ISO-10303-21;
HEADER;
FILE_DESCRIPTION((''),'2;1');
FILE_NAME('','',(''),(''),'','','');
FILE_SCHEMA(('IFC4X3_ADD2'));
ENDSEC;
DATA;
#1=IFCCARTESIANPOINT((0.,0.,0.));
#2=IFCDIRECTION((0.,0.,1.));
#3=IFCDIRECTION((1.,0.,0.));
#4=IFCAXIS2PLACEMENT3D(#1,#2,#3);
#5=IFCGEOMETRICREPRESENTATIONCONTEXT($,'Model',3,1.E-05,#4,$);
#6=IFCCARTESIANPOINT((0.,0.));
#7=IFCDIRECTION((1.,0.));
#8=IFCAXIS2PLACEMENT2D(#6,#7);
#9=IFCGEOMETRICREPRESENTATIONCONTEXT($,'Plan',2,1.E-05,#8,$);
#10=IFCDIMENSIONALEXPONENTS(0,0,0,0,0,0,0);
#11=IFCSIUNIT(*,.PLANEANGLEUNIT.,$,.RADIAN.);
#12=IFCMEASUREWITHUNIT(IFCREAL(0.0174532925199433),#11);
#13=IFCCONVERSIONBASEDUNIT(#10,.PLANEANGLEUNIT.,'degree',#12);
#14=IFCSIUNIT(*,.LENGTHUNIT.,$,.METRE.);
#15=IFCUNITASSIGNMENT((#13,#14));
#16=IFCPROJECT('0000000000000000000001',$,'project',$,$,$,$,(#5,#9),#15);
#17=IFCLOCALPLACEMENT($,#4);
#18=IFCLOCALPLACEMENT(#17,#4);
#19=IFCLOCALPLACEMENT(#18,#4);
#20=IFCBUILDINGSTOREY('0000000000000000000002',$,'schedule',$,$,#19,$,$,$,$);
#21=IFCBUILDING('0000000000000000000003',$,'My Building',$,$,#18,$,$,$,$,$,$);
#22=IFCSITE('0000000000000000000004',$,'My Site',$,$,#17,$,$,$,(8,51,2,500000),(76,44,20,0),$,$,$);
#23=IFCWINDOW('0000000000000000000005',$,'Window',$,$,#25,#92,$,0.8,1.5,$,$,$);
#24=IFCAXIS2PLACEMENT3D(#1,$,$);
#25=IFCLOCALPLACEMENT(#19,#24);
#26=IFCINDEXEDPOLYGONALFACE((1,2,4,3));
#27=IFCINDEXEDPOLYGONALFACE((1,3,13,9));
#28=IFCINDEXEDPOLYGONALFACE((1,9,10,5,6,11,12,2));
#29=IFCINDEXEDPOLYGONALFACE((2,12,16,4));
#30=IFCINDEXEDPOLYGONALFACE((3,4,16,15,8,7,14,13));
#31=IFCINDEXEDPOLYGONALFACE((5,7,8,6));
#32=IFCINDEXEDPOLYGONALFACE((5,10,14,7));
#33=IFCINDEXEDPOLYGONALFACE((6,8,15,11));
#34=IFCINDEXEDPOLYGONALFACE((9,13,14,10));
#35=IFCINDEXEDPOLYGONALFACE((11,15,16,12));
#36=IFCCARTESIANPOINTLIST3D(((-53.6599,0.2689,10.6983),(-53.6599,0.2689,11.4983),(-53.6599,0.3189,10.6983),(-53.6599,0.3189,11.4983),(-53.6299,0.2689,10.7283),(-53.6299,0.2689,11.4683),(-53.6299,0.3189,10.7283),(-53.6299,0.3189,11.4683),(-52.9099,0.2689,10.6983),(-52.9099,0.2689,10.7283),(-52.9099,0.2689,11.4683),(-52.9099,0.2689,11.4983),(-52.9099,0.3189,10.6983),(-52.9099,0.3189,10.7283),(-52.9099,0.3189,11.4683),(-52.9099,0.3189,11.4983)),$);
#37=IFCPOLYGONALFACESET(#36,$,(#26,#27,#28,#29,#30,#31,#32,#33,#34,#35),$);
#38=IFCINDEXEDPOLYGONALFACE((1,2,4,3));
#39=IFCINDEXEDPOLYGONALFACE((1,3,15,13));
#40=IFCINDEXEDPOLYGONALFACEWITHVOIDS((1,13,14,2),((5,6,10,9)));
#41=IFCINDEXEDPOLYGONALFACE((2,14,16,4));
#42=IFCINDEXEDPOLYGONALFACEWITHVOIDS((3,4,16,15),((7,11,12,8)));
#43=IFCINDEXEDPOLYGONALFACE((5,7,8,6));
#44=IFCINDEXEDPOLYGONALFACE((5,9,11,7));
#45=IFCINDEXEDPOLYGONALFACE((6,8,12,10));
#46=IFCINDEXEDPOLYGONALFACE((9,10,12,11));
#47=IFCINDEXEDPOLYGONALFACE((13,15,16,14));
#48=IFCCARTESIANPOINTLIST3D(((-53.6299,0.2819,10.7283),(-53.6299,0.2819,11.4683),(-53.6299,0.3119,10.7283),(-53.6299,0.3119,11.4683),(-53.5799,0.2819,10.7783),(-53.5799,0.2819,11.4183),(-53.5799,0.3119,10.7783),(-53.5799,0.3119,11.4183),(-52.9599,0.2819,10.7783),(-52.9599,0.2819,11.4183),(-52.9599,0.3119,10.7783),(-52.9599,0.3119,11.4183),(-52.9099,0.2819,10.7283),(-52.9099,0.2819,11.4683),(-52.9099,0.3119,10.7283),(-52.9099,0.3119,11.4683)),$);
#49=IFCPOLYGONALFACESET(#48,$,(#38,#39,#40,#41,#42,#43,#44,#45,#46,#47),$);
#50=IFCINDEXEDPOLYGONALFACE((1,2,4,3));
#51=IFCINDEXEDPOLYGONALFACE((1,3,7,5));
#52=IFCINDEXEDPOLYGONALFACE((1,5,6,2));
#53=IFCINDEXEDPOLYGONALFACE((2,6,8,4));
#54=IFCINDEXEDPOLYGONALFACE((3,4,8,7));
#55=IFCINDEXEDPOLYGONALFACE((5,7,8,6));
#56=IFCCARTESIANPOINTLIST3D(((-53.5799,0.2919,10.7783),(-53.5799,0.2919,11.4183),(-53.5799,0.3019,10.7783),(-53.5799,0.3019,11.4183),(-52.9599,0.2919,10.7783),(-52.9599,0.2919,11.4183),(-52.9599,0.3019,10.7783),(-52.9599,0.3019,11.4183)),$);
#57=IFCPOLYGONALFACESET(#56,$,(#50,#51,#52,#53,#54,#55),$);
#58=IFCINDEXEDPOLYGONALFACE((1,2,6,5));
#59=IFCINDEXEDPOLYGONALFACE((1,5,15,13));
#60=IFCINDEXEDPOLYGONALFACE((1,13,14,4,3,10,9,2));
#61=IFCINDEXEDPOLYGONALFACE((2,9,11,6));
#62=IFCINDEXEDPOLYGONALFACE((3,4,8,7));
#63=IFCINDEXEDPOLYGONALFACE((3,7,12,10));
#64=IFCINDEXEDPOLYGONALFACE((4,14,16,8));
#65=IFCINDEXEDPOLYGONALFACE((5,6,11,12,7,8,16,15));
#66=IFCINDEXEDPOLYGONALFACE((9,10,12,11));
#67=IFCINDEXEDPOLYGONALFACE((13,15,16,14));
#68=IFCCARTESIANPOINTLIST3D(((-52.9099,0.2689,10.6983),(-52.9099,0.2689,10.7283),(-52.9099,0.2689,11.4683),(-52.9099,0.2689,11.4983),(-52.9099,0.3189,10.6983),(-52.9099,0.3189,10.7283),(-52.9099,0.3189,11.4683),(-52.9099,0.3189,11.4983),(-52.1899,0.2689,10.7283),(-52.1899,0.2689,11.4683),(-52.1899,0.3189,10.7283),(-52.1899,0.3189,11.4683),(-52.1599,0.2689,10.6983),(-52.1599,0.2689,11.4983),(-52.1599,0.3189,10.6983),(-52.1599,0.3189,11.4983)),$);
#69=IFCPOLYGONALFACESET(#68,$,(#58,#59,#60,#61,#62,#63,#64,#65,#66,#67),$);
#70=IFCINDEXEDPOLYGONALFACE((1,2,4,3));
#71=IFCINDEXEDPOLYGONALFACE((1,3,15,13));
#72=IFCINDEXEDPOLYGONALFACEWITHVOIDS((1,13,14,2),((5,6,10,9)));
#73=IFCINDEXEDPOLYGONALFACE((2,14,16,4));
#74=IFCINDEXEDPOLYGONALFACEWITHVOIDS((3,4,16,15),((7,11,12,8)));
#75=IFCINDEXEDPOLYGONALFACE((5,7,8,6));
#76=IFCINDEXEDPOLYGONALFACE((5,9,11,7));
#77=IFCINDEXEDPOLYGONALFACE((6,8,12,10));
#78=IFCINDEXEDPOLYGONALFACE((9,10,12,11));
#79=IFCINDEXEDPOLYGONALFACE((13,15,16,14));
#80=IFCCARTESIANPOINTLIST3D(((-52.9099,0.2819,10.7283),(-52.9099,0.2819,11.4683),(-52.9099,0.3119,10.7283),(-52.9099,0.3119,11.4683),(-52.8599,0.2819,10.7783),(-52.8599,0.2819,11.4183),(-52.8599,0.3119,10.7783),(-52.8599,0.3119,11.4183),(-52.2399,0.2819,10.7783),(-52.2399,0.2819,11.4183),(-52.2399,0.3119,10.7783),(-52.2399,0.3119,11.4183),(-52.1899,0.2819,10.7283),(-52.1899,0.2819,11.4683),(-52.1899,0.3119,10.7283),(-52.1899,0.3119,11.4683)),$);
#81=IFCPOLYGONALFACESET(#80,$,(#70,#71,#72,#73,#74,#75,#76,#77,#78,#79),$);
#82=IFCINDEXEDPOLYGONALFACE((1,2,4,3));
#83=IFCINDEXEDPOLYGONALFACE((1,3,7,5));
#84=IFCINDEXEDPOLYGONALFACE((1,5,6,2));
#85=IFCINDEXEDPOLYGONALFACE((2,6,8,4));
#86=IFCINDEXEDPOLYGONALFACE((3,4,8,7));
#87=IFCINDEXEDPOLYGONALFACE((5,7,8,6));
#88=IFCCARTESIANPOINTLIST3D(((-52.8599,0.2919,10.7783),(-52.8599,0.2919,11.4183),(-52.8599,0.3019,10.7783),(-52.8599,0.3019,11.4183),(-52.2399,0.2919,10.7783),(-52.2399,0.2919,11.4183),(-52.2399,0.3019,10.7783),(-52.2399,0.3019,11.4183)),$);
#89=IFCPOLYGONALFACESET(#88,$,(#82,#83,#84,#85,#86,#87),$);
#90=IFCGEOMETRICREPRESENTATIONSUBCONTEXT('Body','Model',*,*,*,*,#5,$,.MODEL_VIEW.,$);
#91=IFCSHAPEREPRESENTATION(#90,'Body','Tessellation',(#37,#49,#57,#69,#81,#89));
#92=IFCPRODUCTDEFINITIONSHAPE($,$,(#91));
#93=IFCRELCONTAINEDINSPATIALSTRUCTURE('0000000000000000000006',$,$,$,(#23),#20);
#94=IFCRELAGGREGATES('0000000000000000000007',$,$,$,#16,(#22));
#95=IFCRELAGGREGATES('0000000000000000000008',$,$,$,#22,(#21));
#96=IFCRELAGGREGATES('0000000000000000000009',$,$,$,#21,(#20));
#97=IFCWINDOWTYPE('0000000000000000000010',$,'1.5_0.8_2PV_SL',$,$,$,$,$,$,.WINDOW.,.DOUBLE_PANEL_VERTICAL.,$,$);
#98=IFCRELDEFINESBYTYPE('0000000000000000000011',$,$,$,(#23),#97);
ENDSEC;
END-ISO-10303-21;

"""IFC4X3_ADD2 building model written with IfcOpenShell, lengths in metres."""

from ifc_helpers import new_model, entity, si_unit, converted_unit, frame, origin_with_axes, origin_2d_with_axis, place, context, subcontext, project, spatial, line, indexed_curve, outline, extrude, shape, source, transform, mapped, type_object, type_shapes, element, save


model = new_model("IFC4X3_ADD2")

# Units and contexts
model_context = context("Model", 3, precision=1e-05, world=origin_with_axes())
plan_context = context("Plan", 2, precision=1e-05, world=origin_2d_with_axis())
body_context_1 = subcontext(model_context, "Body", "Model", "MODEL_VIEW")
body_context_2 = subcontext(plan_context, "Body", "Plan", "PLAN_VIEW")
ifc_project = project(units=[converted_unit("PLANEANGLEUNIT", "degree", entity("IfcReal", 0.0174532925199433), si_unit("PLANEANGLEUNIT", "RADIAN"), dimensions=[0, 0, 0, 0, 0, 0, 0]), si_unit("LENGTHUNIT", "METRE")], contexts=[model_context, plan_context])

# Site, building, storey
site_placement = place(None, origin_with_axes())
site = spatial("IfcSite", under=ifc_project, at=site_placement, Name="My Site", RefLatitude=(8, 51, 2, 500000), RefLongitude=(76, 44, 20, 0))
building_placement = place(site_placement, origin_with_axes())
building = spatial("IfcBuilding", under=site, at=building_placement, Name="My Building")
storey_placement = place(building_placement, origin_with_axes())
storey = spatial("IfcBuildingStorey", under=building, at=storey_placement, Name="schedule")

# Window
placement_1 = place(storey_placement, frame((-67.8485, 0.2689, 3.1152), z_axis=(0.0, 0.0, 1.0), x_axis=(1.0, 0.0, 0.0)))
window_type_1 = type_object("IfcWindowType", Name="1.5_0.8_2PV_SL", PartitioningType="DOUBLE_PANEL_VERTICAL", PredefinedType="WINDOW")
shared_shape_1 = source(origin_with_axes(), body_context_1, "Body", "SweptSolid", [
    extrude(outline(indexed_curve([(0.75, 0.0), (0.0, 0.0), (0.0, 0.8), (0.75, 0.8), (0.75, 0.77), (0.03, 0.77), (0.03, 0.03), (0.75, 0.03)], segments=[line(1, 2, 3, 4, 5, 6, 7, 8, 1)])), frame((0.0, 0.0, 0.0), z_axis=(0.0, -1.0, 0.0), x_axis=(1.0, 0.0, 0.0)), (0.0, 0.0, -1.0), 0.05),
    extrude(outline(indexed_curve([(0.0, 0.0), (0.72, 0.0), (0.72, 0.74), (0.0, 0.74)], segments=[line(1, 2, 3, 4, 1)]), holes=[indexed_curve([(0.05, 0.05), (0.67, 0.05), (0.67, 0.69), (0.05, 0.69)], segments=[line(1, 2, 3, 4, 1)])]), frame((0.03, 0.013, 0.03), z_axis=(0.0, -1.0, 0.0), x_axis=(1.0, 0.0, 0.0)), (0.0, 0.0, -1.0), 0.03),
    extrude(outline(indexed_curve([(0.05, 0.05), (0.67, 0.05), (0.67, 0.69), (0.05, 0.69)], segments=[line(1, 2, 3, 4, 1)])), frame((0.03, 0.023, 0.03), z_axis=(0.0, -1.0, 0.0), x_axis=(1.0, 0.0, 0.0)), (0.0, 0.0, -1.0), 0.01),
    extrude(outline(indexed_curve([(0.0, 0.8), (0.75, 0.8), (0.75, 0.0), (0.0, 0.0), (0.0, 0.03), (0.72, 0.03), (0.72, 0.77), (0.0, 0.77)], segments=[line(1, 2, 3, 4, 5, 6, 7, 8, 1)])), frame((0.75, 0.0, 0.0), z_axis=(0.0, -1.0, 0.0), x_axis=(1.0, 0.0, 0.0)), (0.0, 0.0, -1.0), 0.05),
    extrude(outline(indexed_curve([(0.0, 0.0), (0.72, 0.0), (0.72, 0.74), (0.0, 0.74)], segments=[line(1, 2, 3, 4, 1)]), holes=[indexed_curve([(0.05, 0.05), (0.67, 0.05), (0.67, 0.69), (0.05, 0.69)], segments=[line(1, 2, 3, 4, 1)])]), frame((0.75, 0.013, 0.03), z_axis=(0.0, -1.0, 0.0), x_axis=(1.0, 0.0, 0.0)), (0.0, 0.0, -1.0), 0.03),
    extrude(outline(indexed_curve([(0.05, 0.05), (0.67, 0.05), (0.67, 0.69), (0.05, 0.69)], segments=[line(1, 2, 3, 4, 1)])), frame((0.75, 0.023, 0.03), z_axis=(0.0, -1.0, 0.0), x_axis=(1.0, 0.0, 0.0)), (0.0, 0.0, -1.0), 0.01),
])
shared_shape_2 = source(origin_with_axes(), body_context_2, "Body", "Curve2D", [
    entity("IfcIndexedPolyCurve", entity("IfcCartesianPointList2D", [[0.03, 0.0], [0.75, 0.0]])),
    entity("IfcIndexedPolyCurve", entity("IfcCartesianPointList2D", [[0.0, 0.05], [0.03, 0.05], [0.03, 0.0], [0.0, 0.0]]), [entity("IfcLineIndex", [1, 2, 3, 4, 1])]),
    entity("IfcIndexedPolyCurve", entity("IfcCartesianPointList2D", [[0.75, 0.05], [0.75, 0.05], [0.75, 0.0], [0.75, 0.0]])),
    entity("IfcIndexedPolyCurve", entity("IfcCartesianPointList2D", [[0.03, 0.013], [0.08, 0.013], [0.08, 0.043], [0.03, 0.043]]), [entity("IfcLineIndex", [1, 2, 3, 4, 1])]),
    entity("IfcIndexedPolyCurve", entity("IfcCartesianPointList2D", [[0.75, 0.013], [0.7, 0.013], [0.7, 0.043], [0.75, 0.043]]), [entity("IfcLineIndex", [1, 2, 3, 4, 1])]),
    entity("IfcIndexedPolyCurve", entity("IfcCartesianPointList2D", [[0.08, 0.013], [0.7, 0.013]])),
    entity("IfcIndexedPolyCurve", entity("IfcCartesianPointList2D", [[0.08, 0.043], [0.7, 0.043]])),
    entity("IfcIndexedPolyCurve", entity("IfcCartesianPointList2D", [[0.08, 0.028], [0.7, 0.028]])),
    entity("IfcIndexedPolyCurve", entity("IfcCartesianPointList2D", [[0.75, 0.0], [1.47, 0.0]])),
    entity("IfcIndexedPolyCurve", entity("IfcCartesianPointList2D", [[0.75, 0.05], [0.75, 0.05], [0.75, 0.0], [0.75, 0.0]])),
    entity("IfcIndexedPolyCurve", entity("IfcCartesianPointList2D", [[1.5, 0.05], [1.47, 0.05], [1.47, 0.0], [1.5, 0.0]]), [entity("IfcLineIndex", [1, 2, 3, 4, 1])]),
    entity("IfcIndexedPolyCurve", entity("IfcCartesianPointList2D", [[0.75, 0.013], [0.8, 0.013], [0.8, 0.043], [0.75, 0.043]]), [entity("IfcLineIndex", [1, 2, 3, 4, 1])]),
    entity("IfcIndexedPolyCurve", entity("IfcCartesianPointList2D", [[1.47, 0.013], [1.42, 0.013], [1.42, 0.043], [1.47, 0.043]]), [entity("IfcLineIndex", [1, 2, 3, 4, 1])]),
    entity("IfcIndexedPolyCurve", entity("IfcCartesianPointList2D", [[0.8, 0.013], [1.42, 0.013]])),
    entity("IfcIndexedPolyCurve", entity("IfcCartesianPointList2D", [[0.8, 0.043], [1.42, 0.043]])),
    entity("IfcIndexedPolyCurve", entity("IfcCartesianPointList2D", [[0.8, 0.028], [1.42, 0.028]])),
])
type_shapes(window_type_1, [shared_shape_1, shared_shape_2])
placement_2 = place(placement_1, frame((14.1887, 0.0, 7.5831), z_axis=(0.0, 0.0, 1.0), x_axis=(1.0, 0.0, 0.0)))
window_1_placement = place(placement_2, origin_with_axes())
element("IfcWindow", 1, at=window_1_placement, inside=storey, type_object=window_type_1, Name="Window", OverallHeight=0.8, OverallWidth=1.5, shapes=[
    shape(body_context_1, "Body", "MappedRepresentation", [mapped(shared_shape_1, transform((0.0, 0.0, 0.0), x_axis=(1.0, 0.0, 0.0), y_axis=(0.0, 1.0, 0.0), z_axis=(0.0, 0.0, 1.0), scale=1.0))]),
    shape(body_context_2, "Body", "MappedRepresentation", [mapped(shared_shape_2, transform((0.0, 0.0, 0.0), x_axis=(1.0, 0.0, 0.0), y_axis=(0.0, 1.0, 0.0), z_axis=(0.0, 0.0, 1.0), scale=1.0))]),
])

save(model, "model.ifc")
